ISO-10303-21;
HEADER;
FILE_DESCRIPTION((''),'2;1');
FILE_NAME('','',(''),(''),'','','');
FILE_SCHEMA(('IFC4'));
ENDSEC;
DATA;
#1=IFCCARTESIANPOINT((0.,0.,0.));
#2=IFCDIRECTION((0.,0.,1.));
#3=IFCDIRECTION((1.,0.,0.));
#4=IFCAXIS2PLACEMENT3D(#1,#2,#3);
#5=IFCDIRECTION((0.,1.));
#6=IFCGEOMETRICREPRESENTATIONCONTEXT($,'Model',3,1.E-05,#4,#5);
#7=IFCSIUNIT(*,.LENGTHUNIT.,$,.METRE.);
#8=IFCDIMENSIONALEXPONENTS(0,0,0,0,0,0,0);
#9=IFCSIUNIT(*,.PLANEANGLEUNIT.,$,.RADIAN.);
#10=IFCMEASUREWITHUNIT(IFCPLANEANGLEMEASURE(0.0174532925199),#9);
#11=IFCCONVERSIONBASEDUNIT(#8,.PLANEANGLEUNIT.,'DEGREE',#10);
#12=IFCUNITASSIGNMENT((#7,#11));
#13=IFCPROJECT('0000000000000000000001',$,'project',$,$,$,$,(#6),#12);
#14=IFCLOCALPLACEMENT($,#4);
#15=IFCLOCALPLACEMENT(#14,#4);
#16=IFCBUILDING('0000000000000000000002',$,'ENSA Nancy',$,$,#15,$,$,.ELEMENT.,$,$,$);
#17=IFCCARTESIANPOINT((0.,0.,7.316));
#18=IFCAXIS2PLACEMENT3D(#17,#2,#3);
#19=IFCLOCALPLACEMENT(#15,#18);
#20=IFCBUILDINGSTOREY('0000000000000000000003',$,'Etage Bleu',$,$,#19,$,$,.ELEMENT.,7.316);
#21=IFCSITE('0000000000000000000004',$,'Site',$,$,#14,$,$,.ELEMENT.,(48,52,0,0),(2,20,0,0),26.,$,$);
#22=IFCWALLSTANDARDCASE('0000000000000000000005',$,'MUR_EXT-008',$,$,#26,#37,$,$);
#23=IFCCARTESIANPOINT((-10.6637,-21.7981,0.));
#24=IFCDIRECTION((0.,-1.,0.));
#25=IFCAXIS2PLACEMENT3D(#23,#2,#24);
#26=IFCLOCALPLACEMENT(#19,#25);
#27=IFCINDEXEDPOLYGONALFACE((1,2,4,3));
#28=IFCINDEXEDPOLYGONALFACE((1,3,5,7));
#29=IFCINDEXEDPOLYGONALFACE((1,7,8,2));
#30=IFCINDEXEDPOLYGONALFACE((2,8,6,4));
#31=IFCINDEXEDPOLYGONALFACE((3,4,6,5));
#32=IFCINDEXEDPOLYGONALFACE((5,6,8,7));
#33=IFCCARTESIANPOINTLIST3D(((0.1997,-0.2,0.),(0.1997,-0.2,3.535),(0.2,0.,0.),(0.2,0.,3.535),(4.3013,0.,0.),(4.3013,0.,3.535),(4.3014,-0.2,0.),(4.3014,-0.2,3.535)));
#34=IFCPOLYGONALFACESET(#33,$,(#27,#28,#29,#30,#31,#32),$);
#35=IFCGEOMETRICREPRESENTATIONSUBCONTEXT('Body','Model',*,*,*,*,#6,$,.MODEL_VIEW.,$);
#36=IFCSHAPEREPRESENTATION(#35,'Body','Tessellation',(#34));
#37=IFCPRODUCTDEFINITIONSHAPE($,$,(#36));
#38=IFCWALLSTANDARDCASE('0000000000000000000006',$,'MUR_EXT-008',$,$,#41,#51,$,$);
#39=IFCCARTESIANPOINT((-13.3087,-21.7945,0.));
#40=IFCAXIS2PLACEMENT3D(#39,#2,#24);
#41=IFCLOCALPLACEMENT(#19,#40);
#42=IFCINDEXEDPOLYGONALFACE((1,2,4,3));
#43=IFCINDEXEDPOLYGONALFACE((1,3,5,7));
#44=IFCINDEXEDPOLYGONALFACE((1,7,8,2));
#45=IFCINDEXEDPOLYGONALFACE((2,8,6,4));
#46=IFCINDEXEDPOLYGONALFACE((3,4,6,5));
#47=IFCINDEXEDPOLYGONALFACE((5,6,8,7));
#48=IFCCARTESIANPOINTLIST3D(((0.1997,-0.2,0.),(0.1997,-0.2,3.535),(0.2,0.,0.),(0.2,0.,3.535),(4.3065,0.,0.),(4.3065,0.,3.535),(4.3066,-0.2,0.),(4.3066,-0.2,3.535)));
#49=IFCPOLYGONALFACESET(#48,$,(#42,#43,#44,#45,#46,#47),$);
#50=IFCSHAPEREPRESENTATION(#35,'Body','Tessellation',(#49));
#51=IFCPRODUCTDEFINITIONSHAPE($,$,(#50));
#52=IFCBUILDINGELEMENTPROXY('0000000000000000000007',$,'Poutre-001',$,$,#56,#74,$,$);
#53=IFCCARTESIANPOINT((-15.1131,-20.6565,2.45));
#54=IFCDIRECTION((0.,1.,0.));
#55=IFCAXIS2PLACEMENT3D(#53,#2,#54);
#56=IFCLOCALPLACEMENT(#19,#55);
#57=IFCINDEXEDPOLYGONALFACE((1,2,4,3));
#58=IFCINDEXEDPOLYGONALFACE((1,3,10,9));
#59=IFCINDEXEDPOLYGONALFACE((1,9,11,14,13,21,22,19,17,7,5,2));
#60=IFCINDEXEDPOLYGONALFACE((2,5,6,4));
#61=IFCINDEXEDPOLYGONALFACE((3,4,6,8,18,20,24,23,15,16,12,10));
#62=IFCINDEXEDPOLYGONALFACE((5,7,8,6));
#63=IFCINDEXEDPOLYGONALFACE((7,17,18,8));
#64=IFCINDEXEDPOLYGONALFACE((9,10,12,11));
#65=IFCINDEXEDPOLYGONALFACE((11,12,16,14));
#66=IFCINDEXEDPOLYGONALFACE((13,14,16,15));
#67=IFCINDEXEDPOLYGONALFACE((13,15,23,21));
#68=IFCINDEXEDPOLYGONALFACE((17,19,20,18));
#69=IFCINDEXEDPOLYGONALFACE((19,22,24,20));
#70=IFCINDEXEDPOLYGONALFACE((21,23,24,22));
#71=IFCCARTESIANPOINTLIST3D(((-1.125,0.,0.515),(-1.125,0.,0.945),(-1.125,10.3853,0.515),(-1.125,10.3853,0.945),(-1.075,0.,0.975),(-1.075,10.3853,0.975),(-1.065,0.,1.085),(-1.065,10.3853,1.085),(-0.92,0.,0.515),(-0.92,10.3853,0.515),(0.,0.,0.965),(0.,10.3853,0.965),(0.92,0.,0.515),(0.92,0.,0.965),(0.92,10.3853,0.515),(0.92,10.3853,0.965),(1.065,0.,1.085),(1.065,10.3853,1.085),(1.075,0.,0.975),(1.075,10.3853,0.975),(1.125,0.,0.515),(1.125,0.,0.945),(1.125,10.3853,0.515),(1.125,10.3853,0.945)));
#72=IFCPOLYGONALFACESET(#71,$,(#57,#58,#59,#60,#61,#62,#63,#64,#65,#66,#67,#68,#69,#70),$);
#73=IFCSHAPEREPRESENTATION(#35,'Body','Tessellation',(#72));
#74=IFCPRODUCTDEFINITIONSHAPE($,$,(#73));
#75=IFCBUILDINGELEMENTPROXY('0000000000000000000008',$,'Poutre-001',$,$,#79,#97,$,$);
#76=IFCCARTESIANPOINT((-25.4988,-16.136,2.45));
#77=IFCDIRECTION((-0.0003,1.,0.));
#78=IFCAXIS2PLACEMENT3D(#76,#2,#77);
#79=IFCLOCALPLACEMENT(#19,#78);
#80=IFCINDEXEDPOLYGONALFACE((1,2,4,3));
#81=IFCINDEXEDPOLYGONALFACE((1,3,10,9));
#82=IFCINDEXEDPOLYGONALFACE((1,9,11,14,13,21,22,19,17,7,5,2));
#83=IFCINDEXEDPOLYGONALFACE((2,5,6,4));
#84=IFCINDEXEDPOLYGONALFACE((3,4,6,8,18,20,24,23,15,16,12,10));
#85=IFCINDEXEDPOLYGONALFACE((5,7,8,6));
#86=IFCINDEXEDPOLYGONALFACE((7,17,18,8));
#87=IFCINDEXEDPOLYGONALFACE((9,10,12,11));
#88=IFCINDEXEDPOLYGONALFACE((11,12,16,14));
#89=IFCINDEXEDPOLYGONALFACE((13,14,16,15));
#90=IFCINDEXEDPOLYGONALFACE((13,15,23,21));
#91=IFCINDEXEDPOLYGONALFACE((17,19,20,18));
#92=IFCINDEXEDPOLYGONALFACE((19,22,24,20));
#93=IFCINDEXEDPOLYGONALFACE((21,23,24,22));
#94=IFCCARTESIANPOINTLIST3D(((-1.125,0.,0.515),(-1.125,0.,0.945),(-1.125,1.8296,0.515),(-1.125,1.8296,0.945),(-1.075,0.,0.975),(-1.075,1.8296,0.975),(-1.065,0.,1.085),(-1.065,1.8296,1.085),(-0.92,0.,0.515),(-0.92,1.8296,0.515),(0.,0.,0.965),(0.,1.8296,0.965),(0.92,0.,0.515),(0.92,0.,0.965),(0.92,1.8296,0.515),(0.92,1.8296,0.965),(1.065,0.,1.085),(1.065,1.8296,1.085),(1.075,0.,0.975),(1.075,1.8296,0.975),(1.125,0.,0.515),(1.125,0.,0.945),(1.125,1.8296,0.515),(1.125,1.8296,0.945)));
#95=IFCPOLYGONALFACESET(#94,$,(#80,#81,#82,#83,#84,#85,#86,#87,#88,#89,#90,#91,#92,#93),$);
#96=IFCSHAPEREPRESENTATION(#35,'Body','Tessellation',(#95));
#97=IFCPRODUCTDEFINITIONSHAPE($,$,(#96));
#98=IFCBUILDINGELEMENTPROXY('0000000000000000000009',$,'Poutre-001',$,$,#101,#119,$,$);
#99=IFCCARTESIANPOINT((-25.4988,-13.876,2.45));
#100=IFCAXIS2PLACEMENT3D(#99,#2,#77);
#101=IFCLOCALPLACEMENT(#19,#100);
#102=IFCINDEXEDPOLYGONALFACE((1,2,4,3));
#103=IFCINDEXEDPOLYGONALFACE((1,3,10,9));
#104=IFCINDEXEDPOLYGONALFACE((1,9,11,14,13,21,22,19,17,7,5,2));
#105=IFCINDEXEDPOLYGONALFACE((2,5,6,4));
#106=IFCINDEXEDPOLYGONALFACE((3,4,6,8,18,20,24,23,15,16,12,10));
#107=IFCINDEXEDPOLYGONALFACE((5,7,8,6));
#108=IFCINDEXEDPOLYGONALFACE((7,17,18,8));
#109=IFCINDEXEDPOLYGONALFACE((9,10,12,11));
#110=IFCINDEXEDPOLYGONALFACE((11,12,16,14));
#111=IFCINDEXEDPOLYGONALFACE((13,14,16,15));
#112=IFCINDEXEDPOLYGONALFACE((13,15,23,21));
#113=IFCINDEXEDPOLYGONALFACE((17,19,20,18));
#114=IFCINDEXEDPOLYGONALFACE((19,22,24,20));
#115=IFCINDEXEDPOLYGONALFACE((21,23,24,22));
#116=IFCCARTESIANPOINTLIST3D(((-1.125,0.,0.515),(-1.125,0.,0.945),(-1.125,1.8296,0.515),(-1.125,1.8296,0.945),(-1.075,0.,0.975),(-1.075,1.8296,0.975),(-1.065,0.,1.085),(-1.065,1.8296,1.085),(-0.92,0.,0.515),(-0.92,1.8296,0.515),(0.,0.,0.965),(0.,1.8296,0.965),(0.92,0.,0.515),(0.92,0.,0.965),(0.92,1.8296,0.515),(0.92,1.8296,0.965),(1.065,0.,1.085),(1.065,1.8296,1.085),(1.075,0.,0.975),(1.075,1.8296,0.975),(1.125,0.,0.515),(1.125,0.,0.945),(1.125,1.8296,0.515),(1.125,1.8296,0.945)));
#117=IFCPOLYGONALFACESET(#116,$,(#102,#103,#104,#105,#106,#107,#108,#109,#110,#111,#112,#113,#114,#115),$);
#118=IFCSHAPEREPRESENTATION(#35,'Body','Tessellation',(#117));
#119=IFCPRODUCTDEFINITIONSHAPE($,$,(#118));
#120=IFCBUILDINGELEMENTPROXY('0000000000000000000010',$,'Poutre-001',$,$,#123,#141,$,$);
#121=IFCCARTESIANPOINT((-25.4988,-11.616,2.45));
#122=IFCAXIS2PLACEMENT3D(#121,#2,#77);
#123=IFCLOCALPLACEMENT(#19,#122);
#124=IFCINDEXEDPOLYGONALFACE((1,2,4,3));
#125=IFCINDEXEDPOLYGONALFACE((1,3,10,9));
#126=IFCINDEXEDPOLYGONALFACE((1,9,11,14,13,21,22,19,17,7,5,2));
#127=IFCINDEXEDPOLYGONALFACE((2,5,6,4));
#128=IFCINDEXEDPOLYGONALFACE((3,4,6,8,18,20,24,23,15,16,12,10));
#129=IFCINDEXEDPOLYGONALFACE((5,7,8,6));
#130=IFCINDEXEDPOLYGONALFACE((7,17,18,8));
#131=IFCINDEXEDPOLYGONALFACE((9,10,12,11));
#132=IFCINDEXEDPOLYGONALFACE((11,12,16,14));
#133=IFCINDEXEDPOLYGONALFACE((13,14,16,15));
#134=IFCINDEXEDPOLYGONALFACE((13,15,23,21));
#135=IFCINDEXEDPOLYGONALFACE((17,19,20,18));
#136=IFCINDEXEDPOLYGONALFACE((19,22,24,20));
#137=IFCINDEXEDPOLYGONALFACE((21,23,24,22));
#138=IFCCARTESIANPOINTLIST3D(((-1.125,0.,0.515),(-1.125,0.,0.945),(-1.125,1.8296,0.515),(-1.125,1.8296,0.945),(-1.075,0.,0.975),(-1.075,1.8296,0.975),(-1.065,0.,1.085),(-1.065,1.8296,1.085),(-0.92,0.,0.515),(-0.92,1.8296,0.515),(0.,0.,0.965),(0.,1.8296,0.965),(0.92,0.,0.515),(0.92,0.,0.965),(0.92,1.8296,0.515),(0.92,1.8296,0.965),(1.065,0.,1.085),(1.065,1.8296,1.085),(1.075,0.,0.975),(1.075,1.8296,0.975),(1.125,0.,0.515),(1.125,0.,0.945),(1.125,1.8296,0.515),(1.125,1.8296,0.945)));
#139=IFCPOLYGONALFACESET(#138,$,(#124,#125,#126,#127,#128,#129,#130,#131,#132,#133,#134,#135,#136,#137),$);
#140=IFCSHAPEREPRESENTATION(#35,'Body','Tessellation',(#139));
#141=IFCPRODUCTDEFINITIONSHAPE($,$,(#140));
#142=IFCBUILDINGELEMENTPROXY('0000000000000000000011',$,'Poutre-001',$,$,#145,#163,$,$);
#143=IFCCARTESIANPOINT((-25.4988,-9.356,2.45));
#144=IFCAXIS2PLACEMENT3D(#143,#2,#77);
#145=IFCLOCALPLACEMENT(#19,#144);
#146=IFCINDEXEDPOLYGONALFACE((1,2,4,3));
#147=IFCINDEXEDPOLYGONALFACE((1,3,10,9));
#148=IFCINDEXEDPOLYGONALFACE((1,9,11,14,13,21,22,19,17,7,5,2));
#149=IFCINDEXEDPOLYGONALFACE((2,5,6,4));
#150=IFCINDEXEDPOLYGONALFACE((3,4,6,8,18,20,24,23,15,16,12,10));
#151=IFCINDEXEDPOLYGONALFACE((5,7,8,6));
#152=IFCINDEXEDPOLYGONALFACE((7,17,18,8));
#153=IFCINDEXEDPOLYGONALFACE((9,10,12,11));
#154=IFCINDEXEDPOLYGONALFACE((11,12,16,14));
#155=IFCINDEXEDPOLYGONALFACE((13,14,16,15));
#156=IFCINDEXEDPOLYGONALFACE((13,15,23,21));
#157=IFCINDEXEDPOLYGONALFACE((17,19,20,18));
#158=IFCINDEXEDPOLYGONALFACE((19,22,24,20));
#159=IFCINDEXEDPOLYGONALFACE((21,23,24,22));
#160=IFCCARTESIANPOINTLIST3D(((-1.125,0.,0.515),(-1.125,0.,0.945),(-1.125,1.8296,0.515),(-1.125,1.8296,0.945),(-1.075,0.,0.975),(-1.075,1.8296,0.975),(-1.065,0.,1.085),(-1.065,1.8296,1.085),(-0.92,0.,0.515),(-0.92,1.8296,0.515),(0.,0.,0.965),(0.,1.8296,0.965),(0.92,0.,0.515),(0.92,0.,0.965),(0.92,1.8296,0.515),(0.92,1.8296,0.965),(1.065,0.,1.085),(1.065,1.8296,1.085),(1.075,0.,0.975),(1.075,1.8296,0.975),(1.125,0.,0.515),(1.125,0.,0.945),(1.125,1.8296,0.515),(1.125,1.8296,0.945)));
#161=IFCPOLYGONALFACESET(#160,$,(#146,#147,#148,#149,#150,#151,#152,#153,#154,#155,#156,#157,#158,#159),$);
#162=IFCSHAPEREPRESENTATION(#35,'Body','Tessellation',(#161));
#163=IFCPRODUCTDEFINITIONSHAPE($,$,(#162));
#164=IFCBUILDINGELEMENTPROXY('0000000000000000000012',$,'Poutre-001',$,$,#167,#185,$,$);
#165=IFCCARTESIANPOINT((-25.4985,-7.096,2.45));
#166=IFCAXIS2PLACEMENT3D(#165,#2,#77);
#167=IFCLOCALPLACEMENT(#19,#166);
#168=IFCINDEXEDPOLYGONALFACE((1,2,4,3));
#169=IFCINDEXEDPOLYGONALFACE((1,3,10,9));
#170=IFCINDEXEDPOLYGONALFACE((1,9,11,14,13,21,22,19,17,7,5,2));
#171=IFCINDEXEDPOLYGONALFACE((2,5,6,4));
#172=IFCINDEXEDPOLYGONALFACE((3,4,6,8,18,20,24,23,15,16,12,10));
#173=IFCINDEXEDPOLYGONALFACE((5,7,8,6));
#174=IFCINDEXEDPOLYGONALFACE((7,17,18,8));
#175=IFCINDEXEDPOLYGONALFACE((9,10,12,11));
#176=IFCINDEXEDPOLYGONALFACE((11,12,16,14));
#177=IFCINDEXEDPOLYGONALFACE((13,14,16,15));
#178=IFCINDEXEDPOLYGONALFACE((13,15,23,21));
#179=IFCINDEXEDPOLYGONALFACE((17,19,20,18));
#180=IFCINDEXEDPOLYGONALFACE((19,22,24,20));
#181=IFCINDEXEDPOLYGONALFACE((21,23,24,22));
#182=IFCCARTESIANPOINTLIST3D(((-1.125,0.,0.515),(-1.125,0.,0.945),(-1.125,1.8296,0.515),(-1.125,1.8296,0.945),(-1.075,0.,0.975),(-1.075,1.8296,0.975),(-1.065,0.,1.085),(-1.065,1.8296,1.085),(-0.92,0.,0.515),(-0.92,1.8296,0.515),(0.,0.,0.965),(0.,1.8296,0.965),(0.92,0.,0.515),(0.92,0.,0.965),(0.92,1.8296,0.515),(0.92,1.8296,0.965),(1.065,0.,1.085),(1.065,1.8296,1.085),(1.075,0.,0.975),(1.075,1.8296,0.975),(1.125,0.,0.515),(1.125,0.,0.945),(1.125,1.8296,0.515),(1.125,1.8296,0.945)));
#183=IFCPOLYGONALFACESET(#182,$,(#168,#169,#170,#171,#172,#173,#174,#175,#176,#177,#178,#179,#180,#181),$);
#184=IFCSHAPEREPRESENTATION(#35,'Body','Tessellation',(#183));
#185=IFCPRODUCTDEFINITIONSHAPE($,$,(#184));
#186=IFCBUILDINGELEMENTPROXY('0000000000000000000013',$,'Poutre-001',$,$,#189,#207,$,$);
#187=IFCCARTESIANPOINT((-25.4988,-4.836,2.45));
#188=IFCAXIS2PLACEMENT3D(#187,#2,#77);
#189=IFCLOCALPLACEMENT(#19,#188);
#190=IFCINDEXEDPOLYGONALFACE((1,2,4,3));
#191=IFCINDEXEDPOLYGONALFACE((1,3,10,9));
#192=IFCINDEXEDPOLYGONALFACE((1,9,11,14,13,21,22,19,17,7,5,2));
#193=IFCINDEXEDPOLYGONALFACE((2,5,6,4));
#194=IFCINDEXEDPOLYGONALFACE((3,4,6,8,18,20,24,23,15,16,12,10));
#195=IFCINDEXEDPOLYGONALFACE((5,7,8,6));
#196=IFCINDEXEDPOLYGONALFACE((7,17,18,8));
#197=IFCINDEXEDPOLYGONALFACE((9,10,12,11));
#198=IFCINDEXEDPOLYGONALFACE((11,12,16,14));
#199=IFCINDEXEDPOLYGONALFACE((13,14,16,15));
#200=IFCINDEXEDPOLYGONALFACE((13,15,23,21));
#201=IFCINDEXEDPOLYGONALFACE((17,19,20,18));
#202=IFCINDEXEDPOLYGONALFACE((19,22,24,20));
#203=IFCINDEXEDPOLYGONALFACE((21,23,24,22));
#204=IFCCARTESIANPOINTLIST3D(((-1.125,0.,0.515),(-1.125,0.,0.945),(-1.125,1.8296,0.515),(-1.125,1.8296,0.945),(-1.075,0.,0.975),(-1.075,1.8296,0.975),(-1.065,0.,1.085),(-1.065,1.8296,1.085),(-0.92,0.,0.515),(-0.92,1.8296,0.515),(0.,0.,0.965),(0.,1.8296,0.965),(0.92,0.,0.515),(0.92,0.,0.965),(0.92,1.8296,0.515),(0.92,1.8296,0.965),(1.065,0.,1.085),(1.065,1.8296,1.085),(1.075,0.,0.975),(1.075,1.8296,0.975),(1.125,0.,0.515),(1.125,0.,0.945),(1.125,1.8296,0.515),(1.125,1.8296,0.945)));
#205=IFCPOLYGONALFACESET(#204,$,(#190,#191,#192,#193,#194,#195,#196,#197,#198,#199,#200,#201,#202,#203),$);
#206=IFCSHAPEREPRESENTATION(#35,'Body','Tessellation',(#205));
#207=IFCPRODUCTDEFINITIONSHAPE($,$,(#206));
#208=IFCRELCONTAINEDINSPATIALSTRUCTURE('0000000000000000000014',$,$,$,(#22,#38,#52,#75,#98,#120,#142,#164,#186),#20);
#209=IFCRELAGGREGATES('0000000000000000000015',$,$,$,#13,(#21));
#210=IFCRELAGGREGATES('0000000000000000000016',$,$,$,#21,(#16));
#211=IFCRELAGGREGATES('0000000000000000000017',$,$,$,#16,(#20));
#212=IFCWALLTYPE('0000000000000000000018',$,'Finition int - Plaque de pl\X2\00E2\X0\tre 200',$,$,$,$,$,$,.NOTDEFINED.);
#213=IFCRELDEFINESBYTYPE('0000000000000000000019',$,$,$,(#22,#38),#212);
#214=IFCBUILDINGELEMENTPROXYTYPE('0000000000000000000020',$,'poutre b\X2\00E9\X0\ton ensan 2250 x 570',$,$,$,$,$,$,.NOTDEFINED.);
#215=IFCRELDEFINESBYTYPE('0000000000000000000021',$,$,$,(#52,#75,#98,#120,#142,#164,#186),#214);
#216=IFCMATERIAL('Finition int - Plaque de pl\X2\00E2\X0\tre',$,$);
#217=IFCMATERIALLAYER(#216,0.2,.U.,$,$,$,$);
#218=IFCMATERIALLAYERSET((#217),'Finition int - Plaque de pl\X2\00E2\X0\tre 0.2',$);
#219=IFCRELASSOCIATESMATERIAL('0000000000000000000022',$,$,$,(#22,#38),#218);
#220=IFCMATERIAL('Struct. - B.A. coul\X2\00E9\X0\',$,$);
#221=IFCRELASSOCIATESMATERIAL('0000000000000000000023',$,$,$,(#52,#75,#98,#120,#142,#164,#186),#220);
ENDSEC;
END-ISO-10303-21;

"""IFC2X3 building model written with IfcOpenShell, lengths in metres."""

from ifc_helpers import new_model, entity, si_unit, converted_unit, direction, frame, origin_with_axes, place, context, subcontext, project, spatial, polyline, outline, extrude, material, layer, layer_set, layer_usage, type_object, element, save


model = new_model("IFC2X3")

# Units and contexts
model_context = context("Model", 3, precision=1e-05, world=origin_with_axes(), true_north=direction((0.0, 1.0)))
body_context = subcontext(model_context, "Body", "Model", "MODEL_VIEW")
ifc_project = project(units=[si_unit("LENGTHUNIT", "METRE"), converted_unit("PLANEANGLEUNIT", "DEGREE", entity("IfcPlaneAngleMeasure", 0.0174532925199), si_unit("PLANEANGLEUNIT", "RADIAN"), dimensions=[0, 0, 0, 0, 0, 0, 0])], contexts=[model_context])

# Site, building, storey
site_placement = place(None, origin_with_axes())
site = spatial("IfcSite", under=ifc_project, at=site_placement, Name="Site", CompositionType="ELEMENT", RefLatitude=(48, 52, 0, 0), RefLongitude=(2, 20, 0, 0), RefElevation=26.0)
building_placement = place(site_placement, origin_with_axes())
building = spatial("IfcBuilding", under=site, at=building_placement, Name="ENSA Nancy", CompositionType="ELEMENT")
storey_placement = place(building_placement, frame((0.0, 0.0, 7.316), z_axis=(0.0, 0.0, 1.0), x_axis=(1.0, 0.0, 0.0)))
storey = spatial("IfcBuildingStorey", under=building, at=storey_placement, Name="Etage Bleu", CompositionType="ELEMENT", Elevation=7.316)

# Shared definitions
ifc_material_1 = material(Name="Finition int - Plaque de plâtre")
ifc_layer_1 = layer(ifc_material_1, 0.2, ventilated="UNKNOWN")
ifc_layer_set_1 = layer_set([ifc_layer_1], Name="Finition int - Plaque de plâtre 0.2")
wall_type_1 = type_object("IfcWallType", Name="Finition int - Plaque de plâtre 200", PredefinedType="NOTDEFINED")

# Walls
ifc_layer_usage_1 = layer_usage(ifc_layer_set_1, "AXIS2", "NEGATIVE", 0.0)
wall_1_placement = place(storey_placement, frame((-10.6637, -21.7981, 0.0), z_axis=(0.0, 0.0, 1.0), x_axis=(0.0, -1.0, 0.0)))
element("IfcWallStandardCase", 1, at=wall_1_placement, inside=storey, type_object=wall_type_1, material=ifc_layer_usage_1, Name="MUR_EXT-008", context=body_context, shape_type="SweptSolid", body=[
    extrude(outline(polyline([(0.1997, -0.2), (4.3014, -0.2), (4.3013, 0.0), (0.2, 0.0), (0.1997, -0.2)])), origin_with_axes(), (0.0, 0.0, 1.0), 3.535),
])
ifc_layer_usage_2 = layer_usage(ifc_layer_set_1, "AXIS2", "NEGATIVE", 0.0)
wall_2_placement = place(storey_placement, frame((-13.3087, -21.7945, 0.0), z_axis=(0.0, 0.0, 1.0), x_axis=(0.0, -1.0, 0.0)))
element("IfcWallStandardCase", 2, at=wall_2_placement, inside=storey, type_object=wall_type_1, material=ifc_layer_usage_2, Name="MUR_EXT-008", context=body_context, shape_type="SweptSolid", body=[
    extrude(outline(polyline([(0.1997, -0.2), (4.3066, -0.2), (4.3065, 0.0), (0.2, 0.0), (0.1997, -0.2)])), origin_with_axes(), (0.0, 0.0, 1.0), 3.535),
])

# Building element proxies
ifc_material_2 = material(Name="Struct. - B.A. coulé")
building_element_proxy_type_1 = type_object("IfcBuildingElementProxyType", Name="poutre béton ensan 2250 x 570", PredefinedType="NOTDEFINED")
proxy_1_placement = place(storey_placement, frame((-15.1131, -20.6565, 2.45), z_axis=(0.0, 0.0, 1.0), x_axis=(0.0, 1.0, 0.0)))
element("IfcBuildingElementProxy", 3, at=proxy_1_placement, inside=storey, type_object=building_element_proxy_type_1, material=ifc_material_2, Name="Poutre-001", context=body_context, shape_type="SweptSolid", body=[
    extrude(outline(polyline([(-1.065, 1.085), (-1.075, 0.975), (-1.125, 0.945), (-1.125, 0.515), (-0.92, 0.515), (0.0, 0.965), (0.92, 0.965), (0.92, 0.515), (1.125, 0.515), (1.125, 0.945), (1.075, 0.975), (1.065, 1.085), (-1.065, 1.085)])), frame((0.0, 10.3853, 0.0), z_axis=(0.0, -1.0, 0.0), x_axis=(1.0, 0.0, 0.0)), (0.0, 0.0, 1.0), 10.3853),
])
for number, where, z_axis, x_axis, name in (
    (4, (-25.4988, -16.136, 2.45), (0.0, 0.0, 1.0), (-0.0003, 1.0, 0.0), "Poutre-001"),
    (5, (-25.4988, -13.876, 2.45), (0.0, 0.0, 1.0), (-0.0003, 1.0, 0.0), "Poutre-001"),
    (6, (-25.4988, -11.616, 2.45), (0.0, 0.0, 1.0), (-0.0003, 1.0, 0.0), "Poutre-001"),
    (7, (-25.4988, -9.356, 2.45), (0.0, 0.0, 1.0), (-0.0003, 1.0, 0.0), "Poutre-001"),
    (8, (-25.4985, -7.096, 2.45), (0.0, 0.0, 1.0), (-0.0003, 1.0, 0.0), "Poutre-001"),
    (9, (-25.4988, -4.836, 2.45), (0.0, 0.0, 1.0), (-0.0003, 1.0, 0.0), "Poutre-001"),
):
    element("IfcBuildingElementProxy", number, at=place(storey_placement, frame(where, z_axis=z_axis, x_axis=x_axis)), inside=storey, type_object=building_element_proxy_type_1, material=ifc_material_2, Name=name, context=body_context, shape_type="SweptSolid", body=[
        extrude(outline(polyline([(-1.065, 1.085), (-1.075, 0.975), (-1.125, 0.945), (-1.125, 0.515), (-0.92, 0.515), (0.0, 0.965), (0.92, 0.965), (0.92, 0.515), (1.125, 0.515), (1.125, 0.945), (1.075, 0.975), (1.065, 1.085), (-1.065, 1.085)])), frame((0.0, 1.8296, 0.0), z_axis=(0.0, -1.0, 0.0), x_axis=(1.0, 0.0, 0.0)), (0.0, 0.0, 1.0), 1.8296),
    ])

save(model, "model.ifc")
